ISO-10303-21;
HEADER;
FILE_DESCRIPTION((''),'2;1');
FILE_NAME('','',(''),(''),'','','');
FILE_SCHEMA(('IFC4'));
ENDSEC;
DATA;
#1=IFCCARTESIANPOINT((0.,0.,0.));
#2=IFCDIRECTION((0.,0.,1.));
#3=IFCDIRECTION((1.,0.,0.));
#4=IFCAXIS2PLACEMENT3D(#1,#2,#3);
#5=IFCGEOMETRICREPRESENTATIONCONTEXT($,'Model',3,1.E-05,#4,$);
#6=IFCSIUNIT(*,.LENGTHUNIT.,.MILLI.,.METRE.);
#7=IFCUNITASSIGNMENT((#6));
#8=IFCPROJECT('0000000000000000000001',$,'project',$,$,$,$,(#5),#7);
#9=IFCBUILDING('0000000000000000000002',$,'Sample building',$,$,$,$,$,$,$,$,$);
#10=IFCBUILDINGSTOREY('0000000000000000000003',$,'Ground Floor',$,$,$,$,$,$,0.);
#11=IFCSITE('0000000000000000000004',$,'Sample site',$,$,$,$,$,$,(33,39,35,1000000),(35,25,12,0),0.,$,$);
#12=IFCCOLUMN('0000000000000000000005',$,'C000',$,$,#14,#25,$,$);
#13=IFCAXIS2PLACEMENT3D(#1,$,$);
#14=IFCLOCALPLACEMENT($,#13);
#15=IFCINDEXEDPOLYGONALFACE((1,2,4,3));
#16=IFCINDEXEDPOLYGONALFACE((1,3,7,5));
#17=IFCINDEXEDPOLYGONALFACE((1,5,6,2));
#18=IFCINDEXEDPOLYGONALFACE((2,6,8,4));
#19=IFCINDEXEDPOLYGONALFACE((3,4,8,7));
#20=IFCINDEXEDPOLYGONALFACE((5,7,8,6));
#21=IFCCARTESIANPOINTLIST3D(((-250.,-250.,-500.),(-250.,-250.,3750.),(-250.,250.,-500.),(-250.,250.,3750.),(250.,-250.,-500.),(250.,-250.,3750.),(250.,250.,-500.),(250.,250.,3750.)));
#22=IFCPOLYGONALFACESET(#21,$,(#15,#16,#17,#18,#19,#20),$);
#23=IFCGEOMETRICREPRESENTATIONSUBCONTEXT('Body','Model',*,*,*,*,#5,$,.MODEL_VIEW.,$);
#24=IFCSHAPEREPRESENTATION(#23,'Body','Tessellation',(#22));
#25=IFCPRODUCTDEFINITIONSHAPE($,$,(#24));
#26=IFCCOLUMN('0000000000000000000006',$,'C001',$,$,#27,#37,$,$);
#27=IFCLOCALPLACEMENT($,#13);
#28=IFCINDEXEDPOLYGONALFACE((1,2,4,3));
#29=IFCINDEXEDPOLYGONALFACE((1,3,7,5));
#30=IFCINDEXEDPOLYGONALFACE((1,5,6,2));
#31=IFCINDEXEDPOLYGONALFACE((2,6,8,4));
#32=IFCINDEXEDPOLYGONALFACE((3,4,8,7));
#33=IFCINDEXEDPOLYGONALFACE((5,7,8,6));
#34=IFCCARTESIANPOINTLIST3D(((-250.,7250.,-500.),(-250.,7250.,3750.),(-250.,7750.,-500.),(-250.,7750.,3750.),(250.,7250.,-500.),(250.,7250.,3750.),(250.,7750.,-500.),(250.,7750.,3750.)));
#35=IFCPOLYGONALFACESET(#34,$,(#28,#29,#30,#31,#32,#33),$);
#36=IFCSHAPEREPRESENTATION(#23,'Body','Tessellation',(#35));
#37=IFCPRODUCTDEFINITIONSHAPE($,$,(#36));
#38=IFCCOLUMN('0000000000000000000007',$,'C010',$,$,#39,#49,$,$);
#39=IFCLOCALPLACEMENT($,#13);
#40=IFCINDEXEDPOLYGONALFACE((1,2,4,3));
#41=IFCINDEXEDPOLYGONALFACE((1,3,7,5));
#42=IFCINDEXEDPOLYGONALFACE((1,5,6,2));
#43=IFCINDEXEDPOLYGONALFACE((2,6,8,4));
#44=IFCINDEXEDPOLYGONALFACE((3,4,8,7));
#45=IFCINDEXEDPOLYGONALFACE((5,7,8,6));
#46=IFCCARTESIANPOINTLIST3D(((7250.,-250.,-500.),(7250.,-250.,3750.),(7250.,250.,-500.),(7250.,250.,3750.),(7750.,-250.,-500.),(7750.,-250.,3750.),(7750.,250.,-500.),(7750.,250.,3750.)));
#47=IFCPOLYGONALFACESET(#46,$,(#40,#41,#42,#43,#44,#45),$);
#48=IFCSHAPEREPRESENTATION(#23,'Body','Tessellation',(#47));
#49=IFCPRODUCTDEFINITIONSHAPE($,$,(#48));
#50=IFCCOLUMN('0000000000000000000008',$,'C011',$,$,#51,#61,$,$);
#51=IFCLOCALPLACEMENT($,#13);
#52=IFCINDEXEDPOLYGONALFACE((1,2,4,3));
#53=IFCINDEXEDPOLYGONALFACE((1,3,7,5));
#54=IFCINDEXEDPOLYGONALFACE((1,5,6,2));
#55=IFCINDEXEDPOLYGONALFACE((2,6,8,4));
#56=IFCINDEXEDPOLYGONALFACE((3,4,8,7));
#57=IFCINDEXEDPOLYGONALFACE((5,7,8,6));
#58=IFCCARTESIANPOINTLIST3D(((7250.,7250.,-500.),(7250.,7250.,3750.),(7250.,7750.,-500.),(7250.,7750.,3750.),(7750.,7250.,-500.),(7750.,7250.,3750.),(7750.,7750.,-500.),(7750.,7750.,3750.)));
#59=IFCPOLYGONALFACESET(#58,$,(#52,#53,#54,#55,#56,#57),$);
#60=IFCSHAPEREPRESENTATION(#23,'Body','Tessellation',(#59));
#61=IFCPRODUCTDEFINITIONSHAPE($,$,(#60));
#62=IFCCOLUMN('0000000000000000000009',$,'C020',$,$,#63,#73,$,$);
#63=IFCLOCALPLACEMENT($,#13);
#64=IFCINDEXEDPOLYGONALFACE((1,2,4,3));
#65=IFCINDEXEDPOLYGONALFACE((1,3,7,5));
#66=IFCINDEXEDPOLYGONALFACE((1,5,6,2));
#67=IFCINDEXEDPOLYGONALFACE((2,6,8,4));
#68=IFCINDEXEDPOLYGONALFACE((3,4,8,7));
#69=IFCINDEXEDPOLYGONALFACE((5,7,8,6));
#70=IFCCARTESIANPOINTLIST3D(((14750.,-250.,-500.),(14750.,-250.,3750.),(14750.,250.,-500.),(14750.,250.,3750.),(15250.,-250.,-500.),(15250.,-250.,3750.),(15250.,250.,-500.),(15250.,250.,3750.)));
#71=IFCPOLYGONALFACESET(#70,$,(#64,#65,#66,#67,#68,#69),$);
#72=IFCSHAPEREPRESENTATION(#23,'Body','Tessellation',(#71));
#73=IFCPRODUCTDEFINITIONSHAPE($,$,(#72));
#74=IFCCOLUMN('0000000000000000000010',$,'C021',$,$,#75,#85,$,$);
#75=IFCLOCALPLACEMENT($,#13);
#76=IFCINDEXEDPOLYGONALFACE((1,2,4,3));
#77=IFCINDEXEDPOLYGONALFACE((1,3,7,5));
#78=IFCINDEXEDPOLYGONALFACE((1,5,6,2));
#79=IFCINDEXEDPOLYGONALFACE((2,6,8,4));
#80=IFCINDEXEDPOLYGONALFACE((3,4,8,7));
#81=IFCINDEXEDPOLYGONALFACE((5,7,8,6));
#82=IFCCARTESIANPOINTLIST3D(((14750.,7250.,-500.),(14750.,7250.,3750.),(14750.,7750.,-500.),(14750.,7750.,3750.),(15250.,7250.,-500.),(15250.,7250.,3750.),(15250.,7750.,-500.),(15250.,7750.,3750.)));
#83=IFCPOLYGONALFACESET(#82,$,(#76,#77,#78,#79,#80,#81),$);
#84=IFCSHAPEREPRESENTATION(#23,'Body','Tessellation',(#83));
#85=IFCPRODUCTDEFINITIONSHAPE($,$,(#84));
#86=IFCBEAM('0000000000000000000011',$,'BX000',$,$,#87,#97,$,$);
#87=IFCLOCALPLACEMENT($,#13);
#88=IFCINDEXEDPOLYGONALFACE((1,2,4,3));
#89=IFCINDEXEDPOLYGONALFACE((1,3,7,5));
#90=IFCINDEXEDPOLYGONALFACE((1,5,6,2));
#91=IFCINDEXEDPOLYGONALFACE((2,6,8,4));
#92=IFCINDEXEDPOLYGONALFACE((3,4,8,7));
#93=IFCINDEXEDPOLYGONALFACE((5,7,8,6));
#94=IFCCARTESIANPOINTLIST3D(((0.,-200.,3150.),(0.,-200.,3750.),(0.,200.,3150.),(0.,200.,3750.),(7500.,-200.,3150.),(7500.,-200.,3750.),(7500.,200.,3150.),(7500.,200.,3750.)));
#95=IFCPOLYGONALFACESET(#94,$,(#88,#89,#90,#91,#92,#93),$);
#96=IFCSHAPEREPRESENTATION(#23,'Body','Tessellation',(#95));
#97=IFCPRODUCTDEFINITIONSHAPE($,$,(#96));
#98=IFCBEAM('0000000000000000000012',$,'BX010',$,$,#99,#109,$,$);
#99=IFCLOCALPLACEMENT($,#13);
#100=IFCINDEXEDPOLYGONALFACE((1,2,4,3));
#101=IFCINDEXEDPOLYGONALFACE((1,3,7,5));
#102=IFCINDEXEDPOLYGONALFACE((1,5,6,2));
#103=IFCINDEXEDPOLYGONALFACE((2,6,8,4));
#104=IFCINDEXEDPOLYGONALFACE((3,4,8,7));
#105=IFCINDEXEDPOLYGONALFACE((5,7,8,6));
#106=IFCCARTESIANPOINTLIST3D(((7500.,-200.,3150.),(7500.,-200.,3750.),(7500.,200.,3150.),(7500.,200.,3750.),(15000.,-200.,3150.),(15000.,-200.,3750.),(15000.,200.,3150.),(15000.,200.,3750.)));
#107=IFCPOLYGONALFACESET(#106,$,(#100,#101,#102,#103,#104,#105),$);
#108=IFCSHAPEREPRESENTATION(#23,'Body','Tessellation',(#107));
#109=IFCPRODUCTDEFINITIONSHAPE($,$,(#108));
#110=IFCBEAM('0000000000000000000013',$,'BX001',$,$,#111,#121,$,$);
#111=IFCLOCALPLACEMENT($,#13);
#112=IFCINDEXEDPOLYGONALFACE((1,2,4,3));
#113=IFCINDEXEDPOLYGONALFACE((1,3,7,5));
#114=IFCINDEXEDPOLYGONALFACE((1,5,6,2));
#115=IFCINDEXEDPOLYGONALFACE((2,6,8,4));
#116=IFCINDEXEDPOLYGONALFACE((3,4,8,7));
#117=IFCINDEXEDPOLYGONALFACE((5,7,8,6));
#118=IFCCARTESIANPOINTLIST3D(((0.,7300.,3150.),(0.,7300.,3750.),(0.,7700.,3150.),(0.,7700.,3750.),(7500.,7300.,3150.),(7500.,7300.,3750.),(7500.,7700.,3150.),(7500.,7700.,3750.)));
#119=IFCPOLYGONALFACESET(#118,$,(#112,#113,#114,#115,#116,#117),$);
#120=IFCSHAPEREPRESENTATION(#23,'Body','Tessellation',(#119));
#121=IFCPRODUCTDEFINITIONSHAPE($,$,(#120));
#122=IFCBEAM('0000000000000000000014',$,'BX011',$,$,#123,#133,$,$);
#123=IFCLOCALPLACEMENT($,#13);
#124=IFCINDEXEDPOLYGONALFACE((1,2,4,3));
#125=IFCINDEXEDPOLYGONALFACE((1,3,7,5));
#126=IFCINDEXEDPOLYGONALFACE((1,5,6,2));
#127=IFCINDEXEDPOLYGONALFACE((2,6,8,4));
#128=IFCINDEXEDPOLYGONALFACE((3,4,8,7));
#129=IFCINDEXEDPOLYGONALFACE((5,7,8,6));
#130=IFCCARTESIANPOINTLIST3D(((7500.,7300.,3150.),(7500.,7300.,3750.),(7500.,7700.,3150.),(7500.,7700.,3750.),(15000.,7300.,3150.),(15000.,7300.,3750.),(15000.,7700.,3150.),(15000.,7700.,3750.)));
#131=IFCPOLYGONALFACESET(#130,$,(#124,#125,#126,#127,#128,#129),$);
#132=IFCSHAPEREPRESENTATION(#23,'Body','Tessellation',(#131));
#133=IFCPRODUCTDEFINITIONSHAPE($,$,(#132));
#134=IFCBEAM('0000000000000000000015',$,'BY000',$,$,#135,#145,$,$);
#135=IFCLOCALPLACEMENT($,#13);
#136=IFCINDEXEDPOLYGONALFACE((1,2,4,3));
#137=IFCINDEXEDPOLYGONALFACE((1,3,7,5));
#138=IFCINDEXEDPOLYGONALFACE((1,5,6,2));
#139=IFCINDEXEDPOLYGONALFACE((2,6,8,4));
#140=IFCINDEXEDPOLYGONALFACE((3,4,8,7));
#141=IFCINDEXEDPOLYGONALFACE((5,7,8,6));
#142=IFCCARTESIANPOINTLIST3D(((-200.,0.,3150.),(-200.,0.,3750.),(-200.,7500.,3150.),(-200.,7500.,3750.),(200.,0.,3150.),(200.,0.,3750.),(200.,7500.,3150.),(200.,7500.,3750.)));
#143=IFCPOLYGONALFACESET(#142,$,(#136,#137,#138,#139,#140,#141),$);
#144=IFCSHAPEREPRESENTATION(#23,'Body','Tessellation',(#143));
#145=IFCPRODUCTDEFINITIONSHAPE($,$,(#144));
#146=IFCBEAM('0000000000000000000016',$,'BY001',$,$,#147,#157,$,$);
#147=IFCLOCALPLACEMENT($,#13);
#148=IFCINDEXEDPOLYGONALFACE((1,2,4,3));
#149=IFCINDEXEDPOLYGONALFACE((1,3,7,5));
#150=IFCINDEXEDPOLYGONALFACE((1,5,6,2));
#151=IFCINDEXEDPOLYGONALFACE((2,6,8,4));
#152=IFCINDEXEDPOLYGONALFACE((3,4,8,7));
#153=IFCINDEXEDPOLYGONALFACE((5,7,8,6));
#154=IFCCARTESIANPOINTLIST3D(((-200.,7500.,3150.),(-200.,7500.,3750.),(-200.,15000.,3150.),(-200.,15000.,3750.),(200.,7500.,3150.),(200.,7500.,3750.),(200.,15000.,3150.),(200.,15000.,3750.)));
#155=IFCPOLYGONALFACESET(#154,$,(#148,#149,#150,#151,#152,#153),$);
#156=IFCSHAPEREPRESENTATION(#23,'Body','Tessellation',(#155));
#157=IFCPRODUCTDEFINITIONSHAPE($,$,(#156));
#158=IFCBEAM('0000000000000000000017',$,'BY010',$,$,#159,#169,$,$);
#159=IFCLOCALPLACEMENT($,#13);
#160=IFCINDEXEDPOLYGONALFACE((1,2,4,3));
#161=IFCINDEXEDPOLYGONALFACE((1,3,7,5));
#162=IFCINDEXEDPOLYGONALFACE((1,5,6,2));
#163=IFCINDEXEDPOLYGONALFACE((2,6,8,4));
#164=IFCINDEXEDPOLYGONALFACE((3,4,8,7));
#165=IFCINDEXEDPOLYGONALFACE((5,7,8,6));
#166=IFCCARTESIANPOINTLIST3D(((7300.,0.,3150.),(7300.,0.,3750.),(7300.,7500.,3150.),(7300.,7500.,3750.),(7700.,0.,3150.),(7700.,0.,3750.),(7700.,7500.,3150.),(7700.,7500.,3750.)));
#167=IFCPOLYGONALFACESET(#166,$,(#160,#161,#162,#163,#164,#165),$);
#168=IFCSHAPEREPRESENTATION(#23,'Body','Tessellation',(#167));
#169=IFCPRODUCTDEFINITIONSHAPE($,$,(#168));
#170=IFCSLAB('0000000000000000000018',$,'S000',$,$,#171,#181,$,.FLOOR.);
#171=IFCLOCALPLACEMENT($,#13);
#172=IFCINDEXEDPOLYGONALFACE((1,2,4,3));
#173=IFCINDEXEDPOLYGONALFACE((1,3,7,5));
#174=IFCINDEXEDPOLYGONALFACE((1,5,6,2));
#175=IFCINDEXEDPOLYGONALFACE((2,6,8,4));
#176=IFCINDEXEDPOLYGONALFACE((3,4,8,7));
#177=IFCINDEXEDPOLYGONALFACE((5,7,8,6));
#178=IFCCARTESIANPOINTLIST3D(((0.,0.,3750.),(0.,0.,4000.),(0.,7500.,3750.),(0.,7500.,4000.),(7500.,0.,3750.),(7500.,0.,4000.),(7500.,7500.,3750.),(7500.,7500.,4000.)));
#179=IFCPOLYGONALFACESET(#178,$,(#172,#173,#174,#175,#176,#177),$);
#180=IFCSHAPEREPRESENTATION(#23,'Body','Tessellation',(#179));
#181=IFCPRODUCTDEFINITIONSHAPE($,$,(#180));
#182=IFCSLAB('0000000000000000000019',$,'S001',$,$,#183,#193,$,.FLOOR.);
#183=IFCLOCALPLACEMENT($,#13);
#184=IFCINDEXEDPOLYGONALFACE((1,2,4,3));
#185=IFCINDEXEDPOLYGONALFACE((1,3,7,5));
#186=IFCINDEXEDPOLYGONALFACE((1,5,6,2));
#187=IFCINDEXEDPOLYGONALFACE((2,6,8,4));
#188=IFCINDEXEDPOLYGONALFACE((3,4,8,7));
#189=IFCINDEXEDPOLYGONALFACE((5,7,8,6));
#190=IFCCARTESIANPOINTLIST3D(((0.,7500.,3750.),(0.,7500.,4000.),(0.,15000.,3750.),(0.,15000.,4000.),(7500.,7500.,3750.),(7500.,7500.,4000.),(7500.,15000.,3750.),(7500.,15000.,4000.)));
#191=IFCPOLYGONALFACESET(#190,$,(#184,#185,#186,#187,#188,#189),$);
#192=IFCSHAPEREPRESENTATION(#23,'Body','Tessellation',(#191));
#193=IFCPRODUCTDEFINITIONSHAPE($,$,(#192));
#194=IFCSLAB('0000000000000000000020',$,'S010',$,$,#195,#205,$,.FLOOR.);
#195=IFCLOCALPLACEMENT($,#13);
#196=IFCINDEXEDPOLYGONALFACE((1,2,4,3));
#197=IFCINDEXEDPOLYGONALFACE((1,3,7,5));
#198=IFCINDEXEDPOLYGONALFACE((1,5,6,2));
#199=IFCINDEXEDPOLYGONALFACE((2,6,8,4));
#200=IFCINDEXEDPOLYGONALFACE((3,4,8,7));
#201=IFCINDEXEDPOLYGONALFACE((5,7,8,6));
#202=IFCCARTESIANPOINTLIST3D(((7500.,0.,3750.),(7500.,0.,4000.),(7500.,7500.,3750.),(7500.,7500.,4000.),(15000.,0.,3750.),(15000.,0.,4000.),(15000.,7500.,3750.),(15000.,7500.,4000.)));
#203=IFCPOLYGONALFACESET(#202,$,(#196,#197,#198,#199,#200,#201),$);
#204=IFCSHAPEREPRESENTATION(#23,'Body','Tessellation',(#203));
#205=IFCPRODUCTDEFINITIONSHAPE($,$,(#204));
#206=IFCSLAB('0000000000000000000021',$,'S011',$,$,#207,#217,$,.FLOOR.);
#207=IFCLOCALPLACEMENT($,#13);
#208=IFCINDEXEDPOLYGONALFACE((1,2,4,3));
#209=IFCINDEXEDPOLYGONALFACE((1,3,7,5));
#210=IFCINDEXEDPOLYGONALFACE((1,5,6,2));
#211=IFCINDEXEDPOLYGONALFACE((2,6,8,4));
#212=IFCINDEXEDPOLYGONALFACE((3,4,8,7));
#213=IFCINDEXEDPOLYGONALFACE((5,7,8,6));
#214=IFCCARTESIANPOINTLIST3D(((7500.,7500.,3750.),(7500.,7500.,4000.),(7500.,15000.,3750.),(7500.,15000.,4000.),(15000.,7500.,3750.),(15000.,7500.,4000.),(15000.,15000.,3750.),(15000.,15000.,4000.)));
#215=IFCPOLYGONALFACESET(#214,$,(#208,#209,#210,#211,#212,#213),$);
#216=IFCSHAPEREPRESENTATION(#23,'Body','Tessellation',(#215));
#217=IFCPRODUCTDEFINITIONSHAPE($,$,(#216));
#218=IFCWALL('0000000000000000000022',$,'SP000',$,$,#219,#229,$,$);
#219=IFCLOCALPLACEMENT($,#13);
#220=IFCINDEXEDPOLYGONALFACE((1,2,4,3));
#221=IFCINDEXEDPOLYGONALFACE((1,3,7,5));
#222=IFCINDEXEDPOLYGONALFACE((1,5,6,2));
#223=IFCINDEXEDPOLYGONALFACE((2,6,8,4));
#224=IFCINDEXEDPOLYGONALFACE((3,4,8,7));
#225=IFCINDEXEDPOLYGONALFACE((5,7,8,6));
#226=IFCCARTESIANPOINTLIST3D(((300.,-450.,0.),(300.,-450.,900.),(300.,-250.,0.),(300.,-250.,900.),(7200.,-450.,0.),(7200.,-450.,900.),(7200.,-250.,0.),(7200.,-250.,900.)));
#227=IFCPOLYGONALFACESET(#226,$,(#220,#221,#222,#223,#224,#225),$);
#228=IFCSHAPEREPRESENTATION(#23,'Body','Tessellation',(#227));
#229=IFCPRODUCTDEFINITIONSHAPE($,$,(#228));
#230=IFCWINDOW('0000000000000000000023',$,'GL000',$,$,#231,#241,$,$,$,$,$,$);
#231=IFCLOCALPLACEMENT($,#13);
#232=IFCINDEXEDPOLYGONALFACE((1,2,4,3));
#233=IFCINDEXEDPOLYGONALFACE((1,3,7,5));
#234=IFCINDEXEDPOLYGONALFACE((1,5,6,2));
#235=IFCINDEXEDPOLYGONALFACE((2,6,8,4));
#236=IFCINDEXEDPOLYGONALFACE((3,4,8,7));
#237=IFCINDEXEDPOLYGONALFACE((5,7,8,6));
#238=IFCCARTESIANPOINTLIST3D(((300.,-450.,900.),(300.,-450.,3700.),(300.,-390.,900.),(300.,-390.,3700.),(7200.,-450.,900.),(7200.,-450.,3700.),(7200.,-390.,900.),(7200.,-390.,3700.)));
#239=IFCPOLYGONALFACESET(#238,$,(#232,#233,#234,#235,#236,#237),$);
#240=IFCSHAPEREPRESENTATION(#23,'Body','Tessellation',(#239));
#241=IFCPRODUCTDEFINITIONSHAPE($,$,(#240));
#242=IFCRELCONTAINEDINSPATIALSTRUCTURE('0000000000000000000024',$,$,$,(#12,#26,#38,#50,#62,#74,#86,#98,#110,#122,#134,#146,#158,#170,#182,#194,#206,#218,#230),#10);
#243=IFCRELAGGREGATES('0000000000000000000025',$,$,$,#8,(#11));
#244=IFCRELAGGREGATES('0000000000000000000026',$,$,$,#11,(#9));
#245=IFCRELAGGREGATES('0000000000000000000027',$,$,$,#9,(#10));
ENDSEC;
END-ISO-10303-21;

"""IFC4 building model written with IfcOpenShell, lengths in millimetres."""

from ifc_helpers import new_model, si_unit, frame, origin_with_axes, place, context, subcontext, project, spatial, indexed_curve, outline, extrude, element, save


model = new_model("IFC4")

# Units and contexts
model_context = context("Model", 3, precision=1e-05, world=origin_with_axes())
body_context = subcontext(model_context, "Body", "Model", "MODEL_VIEW")
ifc_project = project(units=[si_unit("LENGTHUNIT", "METRE", prefix="MILLI")], contexts=[model_context])

# Site, building, storey
site = spatial("IfcSite", under=ifc_project, Name="Sample site", RefLatitude=(33, 39, 35, 1000000), RefLongitude=(35, 25, 12, 0), RefElevation=0.0)
building = spatial("IfcBuilding", under=site, Name="Sample building")
storey = spatial("IfcBuildingStorey", under=building, Name="Ground Floor", Elevation=0.0)

# Columns
for number, where, z_axis, x_axis, name in (
    (1, (-250.0, -250.0, -500.0), (0.0, 0.0, 1.0), (1.0, 0.0, 0.0), "C000"),
    (2, (-250.0, 7250.0, -500.0), (0.0, 0.0, 1.0), (1.0, 0.0, 0.0), "C001"),
    (3, (7250.0, -250.0, -500.0), (0.0, 0.0, 1.0), (1.0, 0.0, 0.0), "C010"),
    (4, (7250.0, 7250.0, -500.0), (0.0, 0.0, 1.0), (1.0, 0.0, 0.0), "C011"),
    (5, (14750.0, -250.0, -500.0), (0.0, 0.0, 1.0), (1.0, 0.0, 0.0), "C020"),
    (6, (14750.0, 7250.0, -500.0), (0.0, 0.0, 1.0), (1.0, 0.0, 0.0), "C021"),
):
    element("IfcColumn", number, at=place(None, frame(where, z_axis=z_axis, x_axis=x_axis)), inside=storey, Name=name, context=body_context, shape_type="SweptSolid", body=[
        extrude(outline(indexed_curve([(0.0, 0.0), (0.0, 500.0), (500.0, 500.0), (500.0, 0.0), (0.0, 0.0)], self_intersect=False)), origin_with_axes(), (0.0, 0.0, 1.0), 4250.0),
    ])

# Beams
for number, where, z_axis, x_axis, name in (
    (7, (0.0, -200.0, 3150.0), (0.0, 0.0, 1.0), (1.0, 0.0, 0.0), "BX000"),
    (8, (7500.0, -200.0, 3150.0), (0.0, 0.0, 1.0), (1.0, 0.0, 0.0), "BX010"),
    (9, (0.0, 7300.0, 3150.0), (0.0, 0.0, 1.0), (1.0, 0.0, 0.0), "BX001"),
    (10, (7500.0, 7300.0, 3150.0), (0.0, 0.0, 1.0), (1.0, 0.0, 0.0), "BX011"),
    (11, (200.0, 0.0, 3150.0), (0.0, 0.0, 1.0), (0.0, 1.0, 0.0), "BY000"),
    (12, (200.0, 7500.0, 3150.0), (0.0, 0.0, 1.0), (0.0, 1.0, 0.0), "BY001"),
    (13, (7700.0, 0.0, 3150.0), (0.0, 0.0, 1.0), (0.0, 1.0, 0.0), "BY010"),
):
    element("IfcBeam", number, at=place(None, frame(where, z_axis=z_axis, x_axis=x_axis)), inside=storey, Name=name, context=body_context, shape_type="SweptSolid", body=[
        extrude(outline(indexed_curve([(0.0, 0.0), (0.0, 400.0), (7500.0, 400.0), (7500.0, 0.0), (0.0, 0.0)], self_intersect=False)), origin_with_axes(), (0.0, 0.0, 1.0), 600.0),
    ])

# Slabs
for number, where, z_axis, x_axis, name in (
    (14, (0.0, 0.0, 3750.0), (0.0, 0.0, 1.0), (1.0, 0.0, 0.0), "S000"),
    (15, (0.0, 7500.0, 3750.0), (0.0, 0.0, 1.0), (1.0, 0.0, 0.0), "S001"),
    (16, (7500.0, 0.0, 3750.0), (0.0, 0.0, 1.0), (1.0, 0.0, 0.0), "S010"),
    (17, (7500.0, 7500.0, 3750.0), (0.0, 0.0, 1.0), (1.0, 0.0, 0.0), "S011"),
):
    element("IfcSlab", number, at=place(None, frame(where, z_axis=z_axis, x_axis=x_axis)), inside=storey, Name=name, PredefinedType="FLOOR", context=body_context, shape_type="SweptSolid", body=[
        extrude(outline(indexed_curve([(0.0, 0.0), (0.0, 7500.0), (7500.0, 7500.0), (7500.0, 0.0), (0.0, 0.0)], self_intersect=False)), origin_with_axes(), (0.0, 0.0, 1.0), 250.0),
    ])

# Wall
wall_1_placement = place(None, frame((300.0, -450.0, 0.0), z_axis=(0.0, 0.0, 1.0), x_axis=(1.0, 0.0, 0.0)))
element("IfcWall", 18, at=wall_1_placement, inside=storey, Name="SP000", context=body_context, shape_type="SweptSolid", body=[
    extrude(outline(indexed_curve([(0.0, 0.0), (0.0, 200.0), (6900.0, 200.0), (6900.0, 0.0), (0.0, 0.0)], self_intersect=False)), origin_with_axes(), (0.0, 0.0, 1.0), 900.0),
])

# Window
window_1_placement = place(None, frame((300.0, -450.0, 900.0), z_axis=(0.0, 0.0, 1.0), x_axis=(1.0, 0.0, 0.0)))
element("IfcWindow", 19, at=window_1_placement, inside=storey, Name="GL000", context=body_context, shape_type="SweptSolid", body=[
    extrude(outline(indexed_curve([(0.0, 0.0), (0.0, 60.0), (6900.0, 60.0), (6900.0, 0.0), (0.0, 0.0)], self_intersect=False)), origin_with_axes(), (0.0, 0.0, 1.0), 2800.0),
])

save(model, "model.ifc")
